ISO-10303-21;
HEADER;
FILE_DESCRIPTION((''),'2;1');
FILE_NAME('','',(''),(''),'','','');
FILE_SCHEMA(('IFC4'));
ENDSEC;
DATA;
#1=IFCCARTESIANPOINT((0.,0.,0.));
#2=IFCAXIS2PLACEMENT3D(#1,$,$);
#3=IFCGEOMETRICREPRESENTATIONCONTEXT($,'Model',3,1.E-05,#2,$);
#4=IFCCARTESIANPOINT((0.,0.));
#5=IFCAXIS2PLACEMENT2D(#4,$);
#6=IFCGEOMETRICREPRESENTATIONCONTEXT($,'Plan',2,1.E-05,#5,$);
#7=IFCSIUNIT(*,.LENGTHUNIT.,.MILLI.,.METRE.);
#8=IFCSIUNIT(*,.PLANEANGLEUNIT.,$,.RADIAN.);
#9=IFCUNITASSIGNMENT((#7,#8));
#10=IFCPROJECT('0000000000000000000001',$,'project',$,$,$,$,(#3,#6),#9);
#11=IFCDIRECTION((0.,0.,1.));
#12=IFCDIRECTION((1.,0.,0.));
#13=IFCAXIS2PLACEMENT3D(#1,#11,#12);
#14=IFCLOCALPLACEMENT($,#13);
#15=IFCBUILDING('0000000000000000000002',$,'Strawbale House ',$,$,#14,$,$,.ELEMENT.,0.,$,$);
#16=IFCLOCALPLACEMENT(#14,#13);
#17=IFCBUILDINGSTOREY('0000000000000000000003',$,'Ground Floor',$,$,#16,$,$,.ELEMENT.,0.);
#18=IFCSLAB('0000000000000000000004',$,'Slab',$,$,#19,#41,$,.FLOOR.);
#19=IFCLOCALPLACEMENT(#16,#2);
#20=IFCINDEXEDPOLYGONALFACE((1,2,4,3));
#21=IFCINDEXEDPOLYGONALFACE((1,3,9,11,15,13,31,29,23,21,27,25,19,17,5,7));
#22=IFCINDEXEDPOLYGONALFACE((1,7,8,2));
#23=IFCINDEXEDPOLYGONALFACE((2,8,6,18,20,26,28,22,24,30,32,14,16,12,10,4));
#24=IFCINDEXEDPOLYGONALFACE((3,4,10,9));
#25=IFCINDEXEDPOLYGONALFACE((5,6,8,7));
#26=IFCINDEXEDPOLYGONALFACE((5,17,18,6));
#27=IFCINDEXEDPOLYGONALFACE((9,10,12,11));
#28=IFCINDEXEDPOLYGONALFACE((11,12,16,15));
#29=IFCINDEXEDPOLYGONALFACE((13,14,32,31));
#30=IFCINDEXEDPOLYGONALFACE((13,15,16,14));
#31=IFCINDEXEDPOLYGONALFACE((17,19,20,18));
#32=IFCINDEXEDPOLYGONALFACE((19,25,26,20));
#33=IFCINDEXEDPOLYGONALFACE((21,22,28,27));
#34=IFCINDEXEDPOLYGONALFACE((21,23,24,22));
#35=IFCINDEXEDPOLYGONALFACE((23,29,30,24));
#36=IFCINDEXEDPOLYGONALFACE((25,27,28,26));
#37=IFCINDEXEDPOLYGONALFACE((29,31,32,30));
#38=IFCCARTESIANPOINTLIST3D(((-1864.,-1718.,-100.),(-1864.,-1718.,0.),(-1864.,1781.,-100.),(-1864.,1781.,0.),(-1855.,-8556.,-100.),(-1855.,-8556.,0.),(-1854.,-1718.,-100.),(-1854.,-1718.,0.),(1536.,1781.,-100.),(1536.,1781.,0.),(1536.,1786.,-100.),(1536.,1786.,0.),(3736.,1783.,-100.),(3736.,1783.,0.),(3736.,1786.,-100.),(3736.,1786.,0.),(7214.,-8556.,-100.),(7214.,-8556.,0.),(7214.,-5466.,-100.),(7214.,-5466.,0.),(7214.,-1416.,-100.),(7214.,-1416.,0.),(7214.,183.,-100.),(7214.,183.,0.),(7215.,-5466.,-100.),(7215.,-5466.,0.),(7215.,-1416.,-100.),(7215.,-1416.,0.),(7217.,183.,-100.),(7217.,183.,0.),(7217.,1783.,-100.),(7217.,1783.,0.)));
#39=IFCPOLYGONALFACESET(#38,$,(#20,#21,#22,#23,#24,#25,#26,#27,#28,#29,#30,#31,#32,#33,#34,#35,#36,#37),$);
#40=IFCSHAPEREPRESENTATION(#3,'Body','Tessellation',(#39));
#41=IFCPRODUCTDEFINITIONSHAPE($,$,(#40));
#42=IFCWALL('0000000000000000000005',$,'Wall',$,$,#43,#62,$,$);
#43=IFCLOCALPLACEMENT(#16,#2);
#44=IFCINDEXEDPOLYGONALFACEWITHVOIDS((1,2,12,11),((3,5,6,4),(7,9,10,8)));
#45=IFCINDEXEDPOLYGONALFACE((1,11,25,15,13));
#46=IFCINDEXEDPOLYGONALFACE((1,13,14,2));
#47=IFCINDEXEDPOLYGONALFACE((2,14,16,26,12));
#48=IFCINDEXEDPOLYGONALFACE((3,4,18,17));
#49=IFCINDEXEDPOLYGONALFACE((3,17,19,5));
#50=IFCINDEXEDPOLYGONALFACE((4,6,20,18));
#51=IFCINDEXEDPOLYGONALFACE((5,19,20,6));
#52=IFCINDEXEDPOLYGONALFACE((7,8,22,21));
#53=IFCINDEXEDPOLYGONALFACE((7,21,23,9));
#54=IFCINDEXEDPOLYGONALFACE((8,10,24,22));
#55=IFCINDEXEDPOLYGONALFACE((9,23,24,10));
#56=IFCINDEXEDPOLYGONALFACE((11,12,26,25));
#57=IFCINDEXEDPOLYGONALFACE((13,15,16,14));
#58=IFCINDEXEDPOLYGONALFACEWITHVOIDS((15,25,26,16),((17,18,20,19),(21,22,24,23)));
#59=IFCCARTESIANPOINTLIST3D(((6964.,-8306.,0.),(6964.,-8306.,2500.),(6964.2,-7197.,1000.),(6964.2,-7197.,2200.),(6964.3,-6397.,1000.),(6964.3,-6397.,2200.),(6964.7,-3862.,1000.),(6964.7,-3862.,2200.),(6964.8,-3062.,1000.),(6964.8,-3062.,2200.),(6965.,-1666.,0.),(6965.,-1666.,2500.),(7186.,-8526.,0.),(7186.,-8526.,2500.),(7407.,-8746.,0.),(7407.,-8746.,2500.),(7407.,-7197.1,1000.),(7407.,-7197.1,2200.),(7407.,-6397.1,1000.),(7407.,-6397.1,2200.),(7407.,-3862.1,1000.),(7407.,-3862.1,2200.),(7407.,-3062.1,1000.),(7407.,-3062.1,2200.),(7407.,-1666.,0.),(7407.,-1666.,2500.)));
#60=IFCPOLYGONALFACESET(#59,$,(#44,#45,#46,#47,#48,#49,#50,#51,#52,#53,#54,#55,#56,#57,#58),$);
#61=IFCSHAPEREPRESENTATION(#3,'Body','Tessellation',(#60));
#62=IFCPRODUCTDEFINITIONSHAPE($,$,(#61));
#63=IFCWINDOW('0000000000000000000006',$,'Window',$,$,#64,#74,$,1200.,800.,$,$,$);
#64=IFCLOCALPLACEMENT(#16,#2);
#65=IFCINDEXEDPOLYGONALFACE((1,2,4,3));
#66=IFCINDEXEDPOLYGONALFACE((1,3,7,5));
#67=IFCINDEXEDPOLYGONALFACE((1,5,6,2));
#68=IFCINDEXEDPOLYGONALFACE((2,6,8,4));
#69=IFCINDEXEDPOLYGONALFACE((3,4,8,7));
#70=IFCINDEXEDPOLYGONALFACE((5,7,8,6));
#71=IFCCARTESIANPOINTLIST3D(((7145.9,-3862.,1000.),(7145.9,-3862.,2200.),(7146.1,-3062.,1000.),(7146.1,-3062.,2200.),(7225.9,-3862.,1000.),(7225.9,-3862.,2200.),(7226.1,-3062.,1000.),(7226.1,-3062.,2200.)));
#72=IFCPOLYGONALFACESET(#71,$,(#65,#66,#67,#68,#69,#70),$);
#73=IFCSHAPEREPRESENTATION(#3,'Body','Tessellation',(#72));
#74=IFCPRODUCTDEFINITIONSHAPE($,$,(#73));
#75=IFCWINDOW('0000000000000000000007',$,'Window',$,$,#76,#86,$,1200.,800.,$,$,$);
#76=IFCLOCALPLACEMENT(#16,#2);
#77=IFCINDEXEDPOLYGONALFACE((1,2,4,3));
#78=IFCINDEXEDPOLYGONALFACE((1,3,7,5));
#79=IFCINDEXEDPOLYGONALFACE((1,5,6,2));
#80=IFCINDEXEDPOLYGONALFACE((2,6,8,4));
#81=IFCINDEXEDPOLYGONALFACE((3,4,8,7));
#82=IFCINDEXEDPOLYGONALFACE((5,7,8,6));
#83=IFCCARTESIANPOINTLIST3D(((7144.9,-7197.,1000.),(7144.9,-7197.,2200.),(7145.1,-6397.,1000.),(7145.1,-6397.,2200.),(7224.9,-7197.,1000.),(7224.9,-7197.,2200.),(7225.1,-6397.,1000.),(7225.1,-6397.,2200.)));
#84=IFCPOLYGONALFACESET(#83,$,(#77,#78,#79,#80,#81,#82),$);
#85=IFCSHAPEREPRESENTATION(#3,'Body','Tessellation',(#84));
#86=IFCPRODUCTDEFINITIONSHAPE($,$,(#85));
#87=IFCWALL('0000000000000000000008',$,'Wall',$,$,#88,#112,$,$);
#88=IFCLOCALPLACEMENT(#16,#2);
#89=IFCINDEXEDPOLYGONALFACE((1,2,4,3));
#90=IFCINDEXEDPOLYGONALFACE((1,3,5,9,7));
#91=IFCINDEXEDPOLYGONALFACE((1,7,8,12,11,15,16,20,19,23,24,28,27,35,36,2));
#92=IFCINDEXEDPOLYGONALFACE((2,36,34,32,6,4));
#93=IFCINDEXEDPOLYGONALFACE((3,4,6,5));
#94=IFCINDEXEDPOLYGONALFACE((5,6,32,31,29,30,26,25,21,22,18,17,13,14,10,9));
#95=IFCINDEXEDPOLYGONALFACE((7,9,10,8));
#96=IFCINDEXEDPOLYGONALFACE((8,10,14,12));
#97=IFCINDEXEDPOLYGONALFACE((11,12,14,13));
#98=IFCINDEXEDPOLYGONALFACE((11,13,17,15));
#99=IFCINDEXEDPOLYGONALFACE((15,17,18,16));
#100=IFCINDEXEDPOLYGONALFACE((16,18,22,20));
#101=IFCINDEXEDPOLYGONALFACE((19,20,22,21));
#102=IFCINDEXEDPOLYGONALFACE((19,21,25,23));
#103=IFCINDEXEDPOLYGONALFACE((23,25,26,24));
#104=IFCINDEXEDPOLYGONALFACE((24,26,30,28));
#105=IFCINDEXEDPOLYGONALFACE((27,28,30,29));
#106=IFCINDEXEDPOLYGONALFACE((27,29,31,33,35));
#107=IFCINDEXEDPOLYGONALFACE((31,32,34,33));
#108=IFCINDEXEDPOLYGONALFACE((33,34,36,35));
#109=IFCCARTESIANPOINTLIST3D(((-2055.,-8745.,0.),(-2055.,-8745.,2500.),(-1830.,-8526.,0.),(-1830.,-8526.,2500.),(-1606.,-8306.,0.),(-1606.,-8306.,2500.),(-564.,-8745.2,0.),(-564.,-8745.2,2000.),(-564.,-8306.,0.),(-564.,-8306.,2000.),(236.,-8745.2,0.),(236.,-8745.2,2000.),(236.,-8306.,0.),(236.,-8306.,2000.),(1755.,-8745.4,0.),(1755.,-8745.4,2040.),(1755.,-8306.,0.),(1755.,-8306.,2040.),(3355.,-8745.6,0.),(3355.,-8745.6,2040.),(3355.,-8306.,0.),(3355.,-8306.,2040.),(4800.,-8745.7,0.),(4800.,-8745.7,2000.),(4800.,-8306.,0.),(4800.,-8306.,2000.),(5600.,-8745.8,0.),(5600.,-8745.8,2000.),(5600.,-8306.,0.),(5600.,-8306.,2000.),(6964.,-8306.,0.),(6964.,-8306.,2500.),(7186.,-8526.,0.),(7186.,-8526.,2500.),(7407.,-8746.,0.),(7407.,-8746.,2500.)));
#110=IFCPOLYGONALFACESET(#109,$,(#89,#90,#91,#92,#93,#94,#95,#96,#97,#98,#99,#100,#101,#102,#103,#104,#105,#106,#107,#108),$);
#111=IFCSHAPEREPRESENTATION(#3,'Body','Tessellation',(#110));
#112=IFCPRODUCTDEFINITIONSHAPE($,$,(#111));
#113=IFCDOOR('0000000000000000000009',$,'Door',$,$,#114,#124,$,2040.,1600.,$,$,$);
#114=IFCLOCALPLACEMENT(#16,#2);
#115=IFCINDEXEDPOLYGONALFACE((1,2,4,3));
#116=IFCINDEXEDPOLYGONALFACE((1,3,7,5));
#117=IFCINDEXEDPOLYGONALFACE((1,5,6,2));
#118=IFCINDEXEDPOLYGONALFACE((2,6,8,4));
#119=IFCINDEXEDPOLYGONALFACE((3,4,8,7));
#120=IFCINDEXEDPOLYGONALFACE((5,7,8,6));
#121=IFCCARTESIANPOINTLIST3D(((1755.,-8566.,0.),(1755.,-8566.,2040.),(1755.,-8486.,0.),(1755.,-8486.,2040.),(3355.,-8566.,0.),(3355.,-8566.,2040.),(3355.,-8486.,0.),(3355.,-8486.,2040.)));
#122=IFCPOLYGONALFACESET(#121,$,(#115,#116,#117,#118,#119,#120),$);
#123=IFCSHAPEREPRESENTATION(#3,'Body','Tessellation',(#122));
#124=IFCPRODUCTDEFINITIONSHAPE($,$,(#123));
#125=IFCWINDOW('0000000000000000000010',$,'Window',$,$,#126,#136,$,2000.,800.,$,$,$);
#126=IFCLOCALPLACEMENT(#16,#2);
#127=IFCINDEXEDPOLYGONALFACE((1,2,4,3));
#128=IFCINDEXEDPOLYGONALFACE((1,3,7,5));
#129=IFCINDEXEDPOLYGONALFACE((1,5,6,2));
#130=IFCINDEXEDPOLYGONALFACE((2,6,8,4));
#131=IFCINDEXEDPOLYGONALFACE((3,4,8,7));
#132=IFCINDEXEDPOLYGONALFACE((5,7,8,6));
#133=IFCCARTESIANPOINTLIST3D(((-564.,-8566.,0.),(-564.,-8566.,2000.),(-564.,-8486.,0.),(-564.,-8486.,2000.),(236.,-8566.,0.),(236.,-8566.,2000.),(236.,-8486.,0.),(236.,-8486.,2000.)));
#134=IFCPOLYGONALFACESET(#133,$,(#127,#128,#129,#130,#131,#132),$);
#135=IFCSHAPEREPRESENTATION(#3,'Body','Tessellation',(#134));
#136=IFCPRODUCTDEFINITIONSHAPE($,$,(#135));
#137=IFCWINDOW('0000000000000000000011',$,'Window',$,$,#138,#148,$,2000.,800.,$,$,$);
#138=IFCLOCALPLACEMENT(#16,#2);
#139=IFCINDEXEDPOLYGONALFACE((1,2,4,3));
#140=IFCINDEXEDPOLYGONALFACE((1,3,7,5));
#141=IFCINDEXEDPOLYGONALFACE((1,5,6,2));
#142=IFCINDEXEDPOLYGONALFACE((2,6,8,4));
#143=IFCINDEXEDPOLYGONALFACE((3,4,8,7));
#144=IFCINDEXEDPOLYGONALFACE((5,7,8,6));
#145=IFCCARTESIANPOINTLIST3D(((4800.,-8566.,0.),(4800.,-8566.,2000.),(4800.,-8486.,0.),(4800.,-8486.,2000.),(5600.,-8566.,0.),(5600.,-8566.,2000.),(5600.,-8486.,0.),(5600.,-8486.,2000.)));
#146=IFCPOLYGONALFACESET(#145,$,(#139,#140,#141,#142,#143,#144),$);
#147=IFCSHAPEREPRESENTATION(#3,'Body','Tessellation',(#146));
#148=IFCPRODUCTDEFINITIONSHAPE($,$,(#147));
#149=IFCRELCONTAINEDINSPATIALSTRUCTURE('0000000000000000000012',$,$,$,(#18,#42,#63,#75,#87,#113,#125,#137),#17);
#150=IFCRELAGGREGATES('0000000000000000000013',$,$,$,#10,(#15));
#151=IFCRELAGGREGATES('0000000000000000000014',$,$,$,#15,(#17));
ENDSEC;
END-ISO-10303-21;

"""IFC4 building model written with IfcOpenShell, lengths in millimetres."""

from ifc_helpers import new_model, si_unit, frame, origin, origin_with_axes, origin_2d, origin_2d_with_axis, place, context, project, spatial, polyline, rectangle, outline, extrude, element, fill, save


model = new_model("IFC4")

# Units and contexts
model_context = context("Model", 3, precision=1e-05, world=origin())
plan_context = context("Plan", 2, precision=1e-05, world=origin_2d())
ifc_project = project(units=[si_unit("LENGTHUNIT", "METRE", prefix="MILLI"), si_unit("PLANEANGLEUNIT", "RADIAN")], contexts=[model_context, plan_context])

# Building, storey
building_placement = place(None, origin_with_axes())
building = spatial("IfcBuilding", under=ifc_project, at=building_placement, Name="Strawbale House ", CompositionType="ELEMENT", ElevationOfRefHeight=0.0)
storey_placement = place(building_placement, origin_with_axes())
storey = spatial("IfcBuildingStorey", under=building, at=storey_placement, Name="Ground Floor", CompositionType="ELEMENT", Elevation=0.0)

# Slab
slab_placement = place(storey_placement, origin_with_axes())
element("IfcSlab", 1, at=slab_placement, inside=storey, Name="Slab", PredefinedType="FLOOR", context=model_context, shape_type="SweptSolid", body=[
    extrude(outline(polyline([(3736.0, 1786.0, 0.0), (1536.0, 1786.0, 0.0), (1536.0, 1781.0, 0.0), (-1864.0, 1781.0, 0.0), (-1864.0, -1718.0, 0.0), (-1854.0, -1718.0, 0.0), (-1855.0, -8556.0, 0.0), (7214.0, -8556.0, 0.0), (7214.0, -5466.0, 0.0), (7215.0, -5466.0, 0.0), (7215.0, -1416.0, 0.0), (7214.0, -1416.0, 0.0), (7214.0, 183.0, 0.0), (7217.0, 183.0, 0.0), (7217.0, 1783.0, 0.0), (3736.0, 1783.0, 0.0), (3736.0, 1786.0, 0.0)])), origin_with_axes(), (0.0, 0.0, -1.0), 100.0),
])

# Wall, openings, windows
wall_1_placement = place(storey_placement, origin_with_axes())
wall_1 = element("IfcWall", 2, at=wall_1_placement, inside=storey, Name="Wall", context=model_context, shape_type="SweptSolid", body=[
    extrude(outline(polyline([(7186.0, -8526.0, 0.0), (6964.0, -8306.0, 0.0), (6965.0, -1666.0, 0.0), (7186.0, -1666.0, 0.0), (7407.0, -1666.0, 0.0), (7407.0, -8746.0, 0.0), (7186.0, -8526.0, 0.0)])), origin_with_axes(), (0.0, 0.0, 1.0), 2500.0),
])
opening_1_placement = place(wall_1_placement, frame((6865.0, -3462.0, 1600.0), z_axis=(0.0, 0.0, 1.0), x_axis=(1.0, 0.0, 0.0)))
opening_1 = element("IfcOpeningElement", 3, at=opening_1_placement, cuts=wall_1, PredefinedType="OPENING", context=model_context, shape_type="SweptSolid", body=[
    extrude(rectangle(XDim=800.0, YDim=1200.0, at=origin_2d_with_axis()), frame((0.0, 0.0, 0.0), z_axis=(6640.0, -1.0, 0.0), x_axis=(1.0, 6640.0, 0.0)), (0.0, 0.0, 1.0), 643.0),
])
opening_2_placement = place(wall_1_placement, frame((6864.0, -6797.0, 1600.0), z_axis=(0.0, 0.0, 1.0), x_axis=(1.0, 0.0, 0.0)))
opening_2 = element("IfcOpeningElement", 4, at=opening_2_placement, cuts=wall_1, PredefinedType="OPENING", context=model_context, shape_type="SweptSolid", body=[
    extrude(rectangle(XDim=800.0, YDim=1200.0, at=origin_2d_with_axis()), frame((0.0, 0.0, 0.0), z_axis=(6640.0, -1.0, 0.0), x_axis=(1.0, 6640.0, 0.0)), (0.0, 0.0, 1.0), 643.0),
])
window_1_placement = place(opening_1_placement, frame((281.0, 0.0, 0.0), z_axis=(0.0, 0.0, 1.0), x_axis=(1.0, 0.0, 0.0)))
window_1 = element("IfcWindow", 5, at=window_1_placement, inside=storey, Name="Window", OverallHeight=1200.0, OverallWidth=800.0, context=model_context, shape_type="SweptSolid", body=[
    extrude(outline(polyline([(400.0, 600.0, 0.0), (400.0, -600.0, 0.0), (-400.0, -600.0, 0.0), (-400.0, 600.0, 0.0), (400.0, 600.0, 0.0)])), frame((0.0, 0.0, 0.0), z_axis=(6640.0, -1.0, 0.0), x_axis=(1.0, 6640.0, 0.0)), (0.0, 0.0, 1.0), 80.0),
])
fill(opening_1, window_1)
window_2_placement = place(opening_2_placement, frame((281.0, 0.0, 0.0), z_axis=(0.0, 0.0, 1.0), x_axis=(1.0, 0.0, 0.0)))
window_2 = element("IfcWindow", 6, at=window_2_placement, inside=storey, Name="Window", OverallHeight=1200.0, OverallWidth=800.0, context=model_context, shape_type="SweptSolid", body=[
    extrude(outline(polyline([(400.0, 600.0, 0.0), (400.0, -600.0, 0.0), (-400.0, -600.0, 0.0), (-400.0, 600.0, 0.0), (400.0, 600.0, 0.0)])), frame((0.0, 0.0, 0.0), z_axis=(6640.0, -1.0, 0.0), x_axis=(1.0, 6640.0, 0.0)), (0.0, 0.0, 1.0), 80.0),
])
fill(opening_2, window_2)

# Wall, openings, door, windows
wall_2_placement = place(storey_placement, origin_with_axes())
wall_2 = element("IfcWall", 7, at=wall_2_placement, inside=storey, Name="Wall", context=model_context, shape_type="SweptSolid", body=[
    extrude(outline(polyline([(-1830.0, -8526.0, 0.0), (-1606.0, -8306.0, 0.0), (6964.0, -8306.0, 0.0), (7186.0, -8526.0, 0.0), (7407.0, -8746.0, 0.0), (-2055.0, -8745.0, 0.0), (-1830.0, -8526.0, 0.0)])), origin_with_axes(), (0.0, 0.0, 1.0), 2500.0),
])
opening_3_placement = place(wall_2_placement, frame((2555.0, -8206.0, 1020.0), z_axis=(0.0, 0.0, 1.0), x_axis=(1.0, 0.0, 0.0)))
opening_3 = element("IfcOpeningElement", 8, at=opening_3_placement, cuts=wall_2, PredefinedType="OPENING", context=model_context, shape_type="SweptSolid", body=[
    extrude(rectangle(XDim=1600.0, YDim=2040.0, at=origin_2d_with_axis()), frame((0.0, 0.0, 0.0), z_axis=(0.0, -8570.0, 0.0), x_axis=(8570.0, 0.0, 0.0)), (0.0, 0.0, 1.0), 639.0),
])
opening_4_placement = place(wall_2_placement, frame((-164.0, -8206.0, 1000.0), z_axis=(0.0, 0.0, 1.0), x_axis=(1.0, 0.0, 0.0)))
opening_4 = element("IfcOpeningElement", 9, at=opening_4_placement, cuts=wall_2, PredefinedType="OPENING", context=model_context, shape_type="SweptSolid", body=[
    extrude(rectangle(XDim=800.0, YDim=2000.0, at=origin_2d_with_axis()), frame((0.0, 0.0, 0.0), z_axis=(0.0, -8570.0, 0.0), x_axis=(8570.0, 0.0, 0.0)), (0.0, 0.0, 1.0), 639.0),
])
opening_5_placement = place(wall_2_placement, frame((5200.0, -8206.0, 1000.0), z_axis=(0.0, 0.0, 1.0), x_axis=(1.0, 0.0, 0.0)))
opening_5 = element("IfcOpeningElement", 10, at=opening_5_placement, cuts=wall_2, PredefinedType="OPENING", context=model_context, shape_type="SweptSolid", body=[
    extrude(rectangle(XDim=800.0, YDim=2000.0, at=origin_2d_with_axis()), frame((0.0, 0.0, 0.0), z_axis=(0.0, -8570.0, 0.0), x_axis=(8570.0, 0.0, 0.0)), (0.0, 0.0, 1.0), 639.0),
])
door_1_placement = place(opening_3_placement, frame((0.0, -280.0, 0.0), z_axis=(0.0, 0.0, 1.0), x_axis=(1.0, 0.0, 0.0)))
door_1 = element("IfcDoor", 11, at=door_1_placement, inside=storey, Name="Door", OverallHeight=2040.0, OverallWidth=1600.0, context=model_context, shape_type="SweptSolid", body=[
    extrude(outline(polyline([(800.0, 1020.0, 0.0), (800.0, -1020.0, 0.0), (-800.0, -1020.0, 0.0), (-800.0, 1020.0, 0.0), (800.0, 1020.0, 0.0)])), frame((0.0, 0.0, 0.0), z_axis=(0.0, -8570.0, 0.0), x_axis=(8570.0, 0.0, 0.0)), (0.0, 0.0, 1.0), 80.0),
])
fill(opening_3, door_1)
window_3_placement = place(opening_4_placement, frame((0.0, -280.0, 0.0), z_axis=(0.0, 0.0, 1.0), x_axis=(1.0, 0.0, 0.0)))
window_3 = element("IfcWindow", 12, at=window_3_placement, inside=storey, Name="Window", OverallHeight=2000.0, OverallWidth=800.0, context=model_context, shape_type="SweptSolid", body=[
    extrude(outline(polyline([(400.0, 1000.0, 0.0), (400.0, -1000.0, 0.0), (-400.0, -1000.0, 0.0), (-400.0, 1000.0, 0.0), (400.0, 1000.0, 0.0)])), frame((0.0, 0.0, 0.0), z_axis=(0.0, -8570.0, 0.0), x_axis=(8570.0, 0.0, 0.0)), (0.0, 0.0, 1.0), 80.0),
])
fill(opening_4, window_3)
window_4_placement = place(opening_5_placement, frame((0.0, -280.0, 0.0), z_axis=(0.0, 0.0, 1.0), x_axis=(1.0, 0.0, 0.0)))
window_4 = element("IfcWindow", 13, at=window_4_placement, inside=storey, Name="Window", OverallHeight=2000.0, OverallWidth=800.0, context=model_context, shape_type="SweptSolid", body=[
    extrude(outline(polyline([(400.0, 1000.0, 0.0), (400.0, -1000.0, 0.0), (-400.0, -1000.0, 0.0), (-400.0, 1000.0, 0.0), (400.0, 1000.0, 0.0)])), frame((0.0, 0.0, 0.0), z_axis=(0.0, -8570.0, 0.0), x_axis=(8570.0, 0.0, 0.0)), (0.0, 0.0, 1.0), 80.0),
])
fill(opening_5, window_4)

save(model, "model.ifc")
